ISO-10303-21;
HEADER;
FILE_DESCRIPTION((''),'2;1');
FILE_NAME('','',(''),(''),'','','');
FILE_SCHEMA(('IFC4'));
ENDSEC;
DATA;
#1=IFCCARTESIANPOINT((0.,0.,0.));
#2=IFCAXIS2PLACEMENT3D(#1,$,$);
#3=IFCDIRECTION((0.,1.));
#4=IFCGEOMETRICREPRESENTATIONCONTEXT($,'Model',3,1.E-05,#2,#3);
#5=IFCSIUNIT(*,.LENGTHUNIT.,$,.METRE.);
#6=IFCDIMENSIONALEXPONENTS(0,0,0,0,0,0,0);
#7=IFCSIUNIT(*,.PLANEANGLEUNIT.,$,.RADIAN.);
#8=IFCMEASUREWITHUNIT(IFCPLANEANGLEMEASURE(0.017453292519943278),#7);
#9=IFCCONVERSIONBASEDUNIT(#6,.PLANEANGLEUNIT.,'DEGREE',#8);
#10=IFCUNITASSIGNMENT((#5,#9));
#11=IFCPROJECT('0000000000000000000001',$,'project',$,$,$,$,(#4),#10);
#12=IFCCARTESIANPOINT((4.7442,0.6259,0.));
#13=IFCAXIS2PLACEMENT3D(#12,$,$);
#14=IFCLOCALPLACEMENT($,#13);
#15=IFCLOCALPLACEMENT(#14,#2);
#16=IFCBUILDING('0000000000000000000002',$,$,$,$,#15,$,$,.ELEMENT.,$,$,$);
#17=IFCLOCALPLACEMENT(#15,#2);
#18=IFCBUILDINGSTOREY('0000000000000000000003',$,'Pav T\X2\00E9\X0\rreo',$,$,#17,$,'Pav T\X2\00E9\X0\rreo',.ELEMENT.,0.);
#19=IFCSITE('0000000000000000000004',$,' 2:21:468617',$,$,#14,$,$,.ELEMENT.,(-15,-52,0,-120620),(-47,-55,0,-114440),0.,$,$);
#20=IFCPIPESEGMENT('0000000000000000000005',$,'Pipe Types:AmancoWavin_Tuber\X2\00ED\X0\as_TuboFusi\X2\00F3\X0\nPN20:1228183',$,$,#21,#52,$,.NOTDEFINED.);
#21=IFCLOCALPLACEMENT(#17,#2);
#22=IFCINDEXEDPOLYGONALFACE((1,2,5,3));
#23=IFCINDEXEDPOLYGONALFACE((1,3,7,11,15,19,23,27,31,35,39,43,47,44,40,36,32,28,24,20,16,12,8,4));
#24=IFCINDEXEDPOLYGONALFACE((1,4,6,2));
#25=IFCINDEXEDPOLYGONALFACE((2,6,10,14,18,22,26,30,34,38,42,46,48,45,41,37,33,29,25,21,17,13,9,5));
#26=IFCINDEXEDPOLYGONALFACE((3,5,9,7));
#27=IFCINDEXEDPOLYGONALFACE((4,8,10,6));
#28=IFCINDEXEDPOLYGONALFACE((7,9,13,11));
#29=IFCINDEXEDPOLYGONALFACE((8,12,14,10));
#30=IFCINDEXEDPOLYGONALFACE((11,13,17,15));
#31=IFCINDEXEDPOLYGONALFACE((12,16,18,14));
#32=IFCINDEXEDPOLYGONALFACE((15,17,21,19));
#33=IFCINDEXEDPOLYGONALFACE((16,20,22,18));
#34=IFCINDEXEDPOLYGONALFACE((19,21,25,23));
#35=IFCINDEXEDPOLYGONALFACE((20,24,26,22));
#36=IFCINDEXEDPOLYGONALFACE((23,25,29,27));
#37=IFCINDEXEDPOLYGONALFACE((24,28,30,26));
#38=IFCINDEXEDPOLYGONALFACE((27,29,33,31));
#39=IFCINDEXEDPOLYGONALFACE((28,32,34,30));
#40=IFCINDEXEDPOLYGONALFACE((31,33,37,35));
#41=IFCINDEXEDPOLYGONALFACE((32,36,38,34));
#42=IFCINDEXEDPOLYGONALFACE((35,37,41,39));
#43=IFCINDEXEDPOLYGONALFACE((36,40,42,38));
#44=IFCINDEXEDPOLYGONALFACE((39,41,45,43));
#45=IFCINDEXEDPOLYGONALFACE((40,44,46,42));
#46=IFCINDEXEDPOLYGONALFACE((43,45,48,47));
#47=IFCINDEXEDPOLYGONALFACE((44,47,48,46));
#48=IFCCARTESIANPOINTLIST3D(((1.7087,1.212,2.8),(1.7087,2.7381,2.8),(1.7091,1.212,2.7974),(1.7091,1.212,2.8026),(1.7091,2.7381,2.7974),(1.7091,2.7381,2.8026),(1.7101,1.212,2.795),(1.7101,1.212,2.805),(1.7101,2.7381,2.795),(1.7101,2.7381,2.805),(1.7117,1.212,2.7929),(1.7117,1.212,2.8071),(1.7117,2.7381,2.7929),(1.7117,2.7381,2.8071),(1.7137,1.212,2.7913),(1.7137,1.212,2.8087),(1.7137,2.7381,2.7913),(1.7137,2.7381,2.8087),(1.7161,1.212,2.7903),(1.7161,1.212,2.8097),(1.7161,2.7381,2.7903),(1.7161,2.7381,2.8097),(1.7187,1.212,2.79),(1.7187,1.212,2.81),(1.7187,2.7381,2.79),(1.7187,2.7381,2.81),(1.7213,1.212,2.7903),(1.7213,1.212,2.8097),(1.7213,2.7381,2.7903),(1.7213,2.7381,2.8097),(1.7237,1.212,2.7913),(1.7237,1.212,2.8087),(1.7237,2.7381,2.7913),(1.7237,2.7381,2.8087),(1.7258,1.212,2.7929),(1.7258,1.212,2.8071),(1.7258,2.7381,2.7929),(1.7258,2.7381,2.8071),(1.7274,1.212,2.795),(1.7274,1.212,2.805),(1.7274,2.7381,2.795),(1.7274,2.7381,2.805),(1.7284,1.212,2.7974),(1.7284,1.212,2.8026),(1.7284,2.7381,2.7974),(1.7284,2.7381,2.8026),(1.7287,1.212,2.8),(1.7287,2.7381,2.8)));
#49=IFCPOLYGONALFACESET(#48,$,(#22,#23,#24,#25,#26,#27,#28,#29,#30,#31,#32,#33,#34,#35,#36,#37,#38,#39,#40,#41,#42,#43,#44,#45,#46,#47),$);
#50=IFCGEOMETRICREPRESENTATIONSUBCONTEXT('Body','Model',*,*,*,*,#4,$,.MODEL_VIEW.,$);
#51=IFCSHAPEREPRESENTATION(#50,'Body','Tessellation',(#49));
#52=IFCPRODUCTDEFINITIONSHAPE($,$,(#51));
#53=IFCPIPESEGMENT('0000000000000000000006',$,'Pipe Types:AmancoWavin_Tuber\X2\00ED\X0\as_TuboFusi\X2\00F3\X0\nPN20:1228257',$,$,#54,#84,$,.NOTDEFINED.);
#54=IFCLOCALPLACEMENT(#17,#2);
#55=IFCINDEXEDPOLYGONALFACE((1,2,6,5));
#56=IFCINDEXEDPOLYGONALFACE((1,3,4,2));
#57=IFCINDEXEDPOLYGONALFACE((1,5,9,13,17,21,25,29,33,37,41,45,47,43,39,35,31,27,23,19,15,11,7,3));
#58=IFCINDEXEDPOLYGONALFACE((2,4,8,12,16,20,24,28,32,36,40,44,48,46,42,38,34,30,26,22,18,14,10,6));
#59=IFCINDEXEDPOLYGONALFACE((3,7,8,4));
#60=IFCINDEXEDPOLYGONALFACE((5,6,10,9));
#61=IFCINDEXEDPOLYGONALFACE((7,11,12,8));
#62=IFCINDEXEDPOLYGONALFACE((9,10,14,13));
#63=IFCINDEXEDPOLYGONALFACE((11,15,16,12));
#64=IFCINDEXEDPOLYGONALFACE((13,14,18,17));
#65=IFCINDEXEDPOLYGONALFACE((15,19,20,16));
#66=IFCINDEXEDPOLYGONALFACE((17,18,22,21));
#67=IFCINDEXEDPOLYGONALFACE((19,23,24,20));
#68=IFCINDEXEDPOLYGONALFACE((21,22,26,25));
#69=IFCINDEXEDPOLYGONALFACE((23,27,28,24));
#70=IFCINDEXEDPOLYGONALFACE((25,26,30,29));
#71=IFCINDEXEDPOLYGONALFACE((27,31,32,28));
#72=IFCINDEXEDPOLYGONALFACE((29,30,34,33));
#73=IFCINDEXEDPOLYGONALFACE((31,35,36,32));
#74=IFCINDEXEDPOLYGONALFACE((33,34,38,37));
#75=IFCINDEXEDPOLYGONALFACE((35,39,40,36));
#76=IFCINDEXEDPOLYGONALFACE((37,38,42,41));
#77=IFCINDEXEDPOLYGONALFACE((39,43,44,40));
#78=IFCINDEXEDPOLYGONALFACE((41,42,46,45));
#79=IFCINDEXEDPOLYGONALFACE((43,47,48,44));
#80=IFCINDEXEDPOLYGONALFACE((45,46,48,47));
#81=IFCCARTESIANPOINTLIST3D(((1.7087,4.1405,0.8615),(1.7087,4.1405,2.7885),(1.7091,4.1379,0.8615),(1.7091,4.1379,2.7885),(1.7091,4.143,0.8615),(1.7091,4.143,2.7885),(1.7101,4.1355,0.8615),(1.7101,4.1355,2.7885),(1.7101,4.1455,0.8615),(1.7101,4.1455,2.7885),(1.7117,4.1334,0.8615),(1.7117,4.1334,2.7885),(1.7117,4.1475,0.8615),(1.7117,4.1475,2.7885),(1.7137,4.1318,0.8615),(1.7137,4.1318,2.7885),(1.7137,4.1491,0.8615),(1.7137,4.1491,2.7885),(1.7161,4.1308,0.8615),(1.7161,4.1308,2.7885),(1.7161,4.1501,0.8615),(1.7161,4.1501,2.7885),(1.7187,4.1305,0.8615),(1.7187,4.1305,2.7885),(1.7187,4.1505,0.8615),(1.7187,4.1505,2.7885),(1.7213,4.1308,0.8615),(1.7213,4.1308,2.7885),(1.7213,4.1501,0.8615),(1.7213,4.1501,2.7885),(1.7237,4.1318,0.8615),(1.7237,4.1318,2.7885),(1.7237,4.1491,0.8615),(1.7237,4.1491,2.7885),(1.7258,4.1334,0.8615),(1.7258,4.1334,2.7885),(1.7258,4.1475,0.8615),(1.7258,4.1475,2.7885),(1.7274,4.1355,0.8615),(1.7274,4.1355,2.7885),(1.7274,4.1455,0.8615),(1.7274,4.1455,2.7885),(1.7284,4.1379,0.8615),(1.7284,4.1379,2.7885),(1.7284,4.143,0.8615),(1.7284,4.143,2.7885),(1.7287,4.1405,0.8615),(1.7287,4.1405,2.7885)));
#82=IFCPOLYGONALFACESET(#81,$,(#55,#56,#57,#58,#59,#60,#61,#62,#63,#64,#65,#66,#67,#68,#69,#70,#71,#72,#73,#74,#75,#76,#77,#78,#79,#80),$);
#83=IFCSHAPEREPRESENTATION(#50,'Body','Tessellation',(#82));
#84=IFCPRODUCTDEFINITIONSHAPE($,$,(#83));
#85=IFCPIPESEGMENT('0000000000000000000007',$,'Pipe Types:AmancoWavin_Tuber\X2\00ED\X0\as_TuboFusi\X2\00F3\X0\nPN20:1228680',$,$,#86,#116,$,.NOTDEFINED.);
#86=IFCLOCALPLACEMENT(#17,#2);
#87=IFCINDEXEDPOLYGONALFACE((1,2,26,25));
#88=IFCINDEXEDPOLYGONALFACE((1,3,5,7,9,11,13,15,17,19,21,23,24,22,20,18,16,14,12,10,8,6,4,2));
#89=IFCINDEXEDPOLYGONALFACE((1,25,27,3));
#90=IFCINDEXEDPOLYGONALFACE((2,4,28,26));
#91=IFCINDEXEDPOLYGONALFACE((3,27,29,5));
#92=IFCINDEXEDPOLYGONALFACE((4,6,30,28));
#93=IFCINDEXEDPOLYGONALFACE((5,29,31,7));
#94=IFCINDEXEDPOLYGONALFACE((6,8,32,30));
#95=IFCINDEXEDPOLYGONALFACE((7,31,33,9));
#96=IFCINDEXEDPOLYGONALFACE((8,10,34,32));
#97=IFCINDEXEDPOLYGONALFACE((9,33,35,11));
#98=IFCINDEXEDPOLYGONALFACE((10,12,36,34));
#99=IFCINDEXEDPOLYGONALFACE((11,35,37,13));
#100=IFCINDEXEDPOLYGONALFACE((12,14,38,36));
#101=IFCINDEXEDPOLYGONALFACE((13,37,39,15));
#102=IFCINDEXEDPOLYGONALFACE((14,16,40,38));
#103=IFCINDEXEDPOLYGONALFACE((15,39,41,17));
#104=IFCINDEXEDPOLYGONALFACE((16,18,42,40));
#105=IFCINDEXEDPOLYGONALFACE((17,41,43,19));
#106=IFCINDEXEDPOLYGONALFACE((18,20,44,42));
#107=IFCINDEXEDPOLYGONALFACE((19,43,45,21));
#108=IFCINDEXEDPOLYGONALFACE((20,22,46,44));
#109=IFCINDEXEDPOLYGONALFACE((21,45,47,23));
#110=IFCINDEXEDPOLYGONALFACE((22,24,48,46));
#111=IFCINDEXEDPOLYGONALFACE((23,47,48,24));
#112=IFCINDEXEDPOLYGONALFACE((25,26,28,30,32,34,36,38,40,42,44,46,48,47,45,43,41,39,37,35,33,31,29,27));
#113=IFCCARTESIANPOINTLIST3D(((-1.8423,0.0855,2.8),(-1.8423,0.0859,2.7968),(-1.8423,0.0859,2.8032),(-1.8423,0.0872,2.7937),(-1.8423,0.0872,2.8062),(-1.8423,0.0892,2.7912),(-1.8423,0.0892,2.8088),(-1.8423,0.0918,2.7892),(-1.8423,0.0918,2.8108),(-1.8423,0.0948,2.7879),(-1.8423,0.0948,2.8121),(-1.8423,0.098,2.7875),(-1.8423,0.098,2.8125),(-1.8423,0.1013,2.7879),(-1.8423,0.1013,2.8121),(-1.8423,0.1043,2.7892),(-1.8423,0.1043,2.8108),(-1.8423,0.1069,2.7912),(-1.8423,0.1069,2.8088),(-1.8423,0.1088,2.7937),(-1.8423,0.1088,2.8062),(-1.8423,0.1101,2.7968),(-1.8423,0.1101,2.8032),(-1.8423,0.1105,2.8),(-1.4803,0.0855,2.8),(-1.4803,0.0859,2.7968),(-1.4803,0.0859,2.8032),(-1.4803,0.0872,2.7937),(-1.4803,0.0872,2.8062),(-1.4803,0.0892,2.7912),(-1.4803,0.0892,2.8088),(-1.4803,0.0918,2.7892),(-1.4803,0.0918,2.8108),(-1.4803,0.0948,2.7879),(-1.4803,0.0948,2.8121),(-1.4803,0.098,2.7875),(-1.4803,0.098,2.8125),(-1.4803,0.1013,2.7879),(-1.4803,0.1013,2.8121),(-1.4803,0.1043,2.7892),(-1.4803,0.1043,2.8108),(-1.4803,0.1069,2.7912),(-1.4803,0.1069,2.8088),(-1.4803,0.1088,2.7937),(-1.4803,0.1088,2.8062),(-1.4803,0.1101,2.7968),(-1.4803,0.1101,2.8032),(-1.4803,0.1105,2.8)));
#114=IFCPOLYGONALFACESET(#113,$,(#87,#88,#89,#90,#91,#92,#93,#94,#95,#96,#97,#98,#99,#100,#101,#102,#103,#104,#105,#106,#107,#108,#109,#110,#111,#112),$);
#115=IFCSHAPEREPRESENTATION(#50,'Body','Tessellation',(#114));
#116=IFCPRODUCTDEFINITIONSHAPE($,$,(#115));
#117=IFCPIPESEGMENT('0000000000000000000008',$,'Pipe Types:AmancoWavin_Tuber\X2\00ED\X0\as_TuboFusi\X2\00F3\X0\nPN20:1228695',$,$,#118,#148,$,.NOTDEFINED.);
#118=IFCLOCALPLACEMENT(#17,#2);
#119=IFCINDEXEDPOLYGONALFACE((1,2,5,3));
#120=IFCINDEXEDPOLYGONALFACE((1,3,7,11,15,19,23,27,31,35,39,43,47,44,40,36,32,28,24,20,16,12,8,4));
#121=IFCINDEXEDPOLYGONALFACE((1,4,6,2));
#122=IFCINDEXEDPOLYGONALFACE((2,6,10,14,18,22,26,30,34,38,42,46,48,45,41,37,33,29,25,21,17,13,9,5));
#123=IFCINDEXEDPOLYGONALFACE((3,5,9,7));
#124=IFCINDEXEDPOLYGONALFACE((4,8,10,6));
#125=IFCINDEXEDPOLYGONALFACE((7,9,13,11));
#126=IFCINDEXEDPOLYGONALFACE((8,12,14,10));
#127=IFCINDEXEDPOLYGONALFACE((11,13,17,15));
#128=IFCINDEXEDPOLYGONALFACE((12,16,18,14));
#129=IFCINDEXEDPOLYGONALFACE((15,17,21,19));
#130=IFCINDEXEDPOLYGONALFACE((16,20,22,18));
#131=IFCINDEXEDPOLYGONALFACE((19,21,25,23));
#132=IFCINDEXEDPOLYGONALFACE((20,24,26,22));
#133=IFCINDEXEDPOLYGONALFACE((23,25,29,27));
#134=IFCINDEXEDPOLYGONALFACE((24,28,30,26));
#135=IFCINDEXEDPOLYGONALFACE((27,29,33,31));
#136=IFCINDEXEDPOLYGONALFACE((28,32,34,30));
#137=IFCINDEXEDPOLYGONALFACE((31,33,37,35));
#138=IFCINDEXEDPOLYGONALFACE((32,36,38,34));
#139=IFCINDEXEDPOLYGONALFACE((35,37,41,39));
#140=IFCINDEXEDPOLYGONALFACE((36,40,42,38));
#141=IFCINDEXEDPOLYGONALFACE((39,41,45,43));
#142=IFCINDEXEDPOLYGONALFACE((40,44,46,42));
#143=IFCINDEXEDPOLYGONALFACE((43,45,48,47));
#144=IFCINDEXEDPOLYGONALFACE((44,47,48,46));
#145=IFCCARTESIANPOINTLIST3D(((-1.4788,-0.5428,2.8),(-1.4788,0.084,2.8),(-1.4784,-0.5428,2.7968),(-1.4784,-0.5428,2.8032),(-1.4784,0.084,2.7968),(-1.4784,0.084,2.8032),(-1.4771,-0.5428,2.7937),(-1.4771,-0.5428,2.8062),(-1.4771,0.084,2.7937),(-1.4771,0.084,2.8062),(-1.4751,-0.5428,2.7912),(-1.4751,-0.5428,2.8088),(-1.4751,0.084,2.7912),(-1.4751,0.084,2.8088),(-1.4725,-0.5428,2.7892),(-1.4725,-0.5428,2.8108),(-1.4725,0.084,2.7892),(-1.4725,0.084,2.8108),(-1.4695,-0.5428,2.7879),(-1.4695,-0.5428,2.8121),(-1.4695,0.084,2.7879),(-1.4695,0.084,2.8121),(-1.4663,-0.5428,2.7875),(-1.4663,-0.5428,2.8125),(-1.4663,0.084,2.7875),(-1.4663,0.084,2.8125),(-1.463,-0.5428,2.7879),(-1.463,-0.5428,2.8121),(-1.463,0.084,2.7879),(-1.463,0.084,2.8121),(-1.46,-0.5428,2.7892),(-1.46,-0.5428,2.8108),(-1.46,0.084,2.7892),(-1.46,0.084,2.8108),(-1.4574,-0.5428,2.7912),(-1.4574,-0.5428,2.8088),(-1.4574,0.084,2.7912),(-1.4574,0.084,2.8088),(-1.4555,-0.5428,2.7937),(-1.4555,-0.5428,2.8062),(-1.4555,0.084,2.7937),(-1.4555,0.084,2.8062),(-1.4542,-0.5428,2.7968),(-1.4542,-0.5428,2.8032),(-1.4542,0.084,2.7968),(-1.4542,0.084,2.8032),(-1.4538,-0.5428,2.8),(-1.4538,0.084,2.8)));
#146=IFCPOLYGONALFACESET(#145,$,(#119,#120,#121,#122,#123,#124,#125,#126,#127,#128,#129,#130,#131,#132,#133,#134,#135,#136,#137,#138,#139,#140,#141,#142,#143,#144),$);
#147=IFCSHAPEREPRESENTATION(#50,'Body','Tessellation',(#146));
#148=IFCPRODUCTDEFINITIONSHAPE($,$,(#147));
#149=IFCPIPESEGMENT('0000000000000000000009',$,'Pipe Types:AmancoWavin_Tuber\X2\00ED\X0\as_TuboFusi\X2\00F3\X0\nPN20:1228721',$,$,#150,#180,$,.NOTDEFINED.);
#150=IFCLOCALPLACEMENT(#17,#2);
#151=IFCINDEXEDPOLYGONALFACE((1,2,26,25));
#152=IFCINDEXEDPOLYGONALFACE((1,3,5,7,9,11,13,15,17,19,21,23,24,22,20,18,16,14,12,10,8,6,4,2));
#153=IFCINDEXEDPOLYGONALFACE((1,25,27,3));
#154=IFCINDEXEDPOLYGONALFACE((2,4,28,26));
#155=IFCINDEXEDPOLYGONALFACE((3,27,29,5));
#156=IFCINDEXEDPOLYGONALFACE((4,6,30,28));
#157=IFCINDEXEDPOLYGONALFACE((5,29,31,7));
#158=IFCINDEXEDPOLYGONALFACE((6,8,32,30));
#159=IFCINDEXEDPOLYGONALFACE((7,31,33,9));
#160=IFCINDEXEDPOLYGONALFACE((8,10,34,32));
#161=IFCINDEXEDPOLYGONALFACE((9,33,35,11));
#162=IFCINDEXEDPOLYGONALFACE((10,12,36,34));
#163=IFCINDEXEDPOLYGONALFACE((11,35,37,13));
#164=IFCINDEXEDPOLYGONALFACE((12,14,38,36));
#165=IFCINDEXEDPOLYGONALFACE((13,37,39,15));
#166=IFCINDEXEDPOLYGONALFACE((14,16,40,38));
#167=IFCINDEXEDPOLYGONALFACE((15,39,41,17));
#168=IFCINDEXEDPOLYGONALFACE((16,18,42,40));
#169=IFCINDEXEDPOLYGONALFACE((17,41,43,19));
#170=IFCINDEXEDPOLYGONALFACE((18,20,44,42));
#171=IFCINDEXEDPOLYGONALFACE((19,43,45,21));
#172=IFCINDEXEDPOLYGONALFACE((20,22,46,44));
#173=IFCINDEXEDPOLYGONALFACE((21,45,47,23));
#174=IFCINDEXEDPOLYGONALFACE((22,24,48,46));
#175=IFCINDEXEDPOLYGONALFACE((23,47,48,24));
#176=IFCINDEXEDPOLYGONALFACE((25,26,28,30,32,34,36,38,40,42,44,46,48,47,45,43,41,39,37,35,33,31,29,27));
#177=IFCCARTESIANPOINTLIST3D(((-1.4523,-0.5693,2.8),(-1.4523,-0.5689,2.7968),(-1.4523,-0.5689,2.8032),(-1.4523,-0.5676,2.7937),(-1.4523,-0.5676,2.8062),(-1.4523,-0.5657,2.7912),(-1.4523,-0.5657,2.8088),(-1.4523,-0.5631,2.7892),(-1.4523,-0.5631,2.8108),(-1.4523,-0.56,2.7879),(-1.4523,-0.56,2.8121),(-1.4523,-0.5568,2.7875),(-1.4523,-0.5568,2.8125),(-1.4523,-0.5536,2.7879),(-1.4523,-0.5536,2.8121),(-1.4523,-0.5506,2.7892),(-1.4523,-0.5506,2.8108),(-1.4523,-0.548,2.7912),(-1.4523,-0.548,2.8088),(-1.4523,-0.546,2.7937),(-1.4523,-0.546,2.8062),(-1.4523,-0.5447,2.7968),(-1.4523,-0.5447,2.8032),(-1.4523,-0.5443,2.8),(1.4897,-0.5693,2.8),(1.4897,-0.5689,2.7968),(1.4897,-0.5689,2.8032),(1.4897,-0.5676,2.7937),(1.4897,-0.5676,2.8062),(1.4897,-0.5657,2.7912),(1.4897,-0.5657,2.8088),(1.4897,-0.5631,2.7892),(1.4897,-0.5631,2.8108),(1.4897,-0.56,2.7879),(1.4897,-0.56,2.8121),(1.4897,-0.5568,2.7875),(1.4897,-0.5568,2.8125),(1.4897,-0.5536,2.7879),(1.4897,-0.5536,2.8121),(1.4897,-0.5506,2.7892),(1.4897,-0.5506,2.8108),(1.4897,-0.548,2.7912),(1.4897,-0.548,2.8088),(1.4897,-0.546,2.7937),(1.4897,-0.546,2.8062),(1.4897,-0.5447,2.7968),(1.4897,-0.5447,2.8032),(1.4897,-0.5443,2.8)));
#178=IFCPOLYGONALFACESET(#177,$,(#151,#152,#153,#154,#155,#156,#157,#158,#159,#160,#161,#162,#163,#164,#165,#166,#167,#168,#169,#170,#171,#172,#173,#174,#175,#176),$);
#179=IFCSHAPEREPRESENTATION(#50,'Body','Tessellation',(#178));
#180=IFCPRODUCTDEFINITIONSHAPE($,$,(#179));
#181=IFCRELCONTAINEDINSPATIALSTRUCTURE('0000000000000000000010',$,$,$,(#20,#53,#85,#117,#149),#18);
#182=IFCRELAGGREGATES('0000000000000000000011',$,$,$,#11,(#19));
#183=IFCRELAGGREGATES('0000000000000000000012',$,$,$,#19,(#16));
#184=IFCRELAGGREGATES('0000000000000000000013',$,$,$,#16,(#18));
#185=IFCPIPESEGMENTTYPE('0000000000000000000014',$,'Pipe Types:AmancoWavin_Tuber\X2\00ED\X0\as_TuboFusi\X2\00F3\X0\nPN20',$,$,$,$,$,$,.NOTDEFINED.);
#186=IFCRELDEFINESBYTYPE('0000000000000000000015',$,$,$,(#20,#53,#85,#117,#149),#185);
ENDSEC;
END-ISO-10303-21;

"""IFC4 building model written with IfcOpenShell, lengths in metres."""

from ifc_helpers import new_model, entity, si_unit, converted_unit, direction, frame, origin, place, context, subcontext, project, spatial, arc, indexed_curve, outline, extrude, type_object, element, save


model = new_model("IFC4")

# Units and contexts
model_context = context("Model", 3, precision=1e-05, world=origin(), true_north=direction((0.0, 1.0)))
body_context = subcontext(model_context, "Body", "Model", "MODEL_VIEW")
ifc_project = project(units=[si_unit("LENGTHUNIT", "METRE"), converted_unit("PLANEANGLEUNIT", "DEGREE", entity("IfcPlaneAngleMeasure", 0.017453292519943278), si_unit("PLANEANGLEUNIT", "RADIAN"), dimensions=[0, 0, 0, 0, 0, 0, 0])], contexts=[model_context])

# Site, building, storey
site_placement = place(None, frame((4.7442, 0.6259, 0.0)))
site = spatial("IfcSite", under=ifc_project, at=site_placement, Name=" 2:21:468617", CompositionType="ELEMENT", RefLatitude=(-15, -52, 0, -120620), RefLongitude=(-47, -55, 0, -114440), RefElevation=0.0)
building_placement = place(site_placement, origin())
building = spatial("IfcBuilding", under=site, at=building_placement, CompositionType="ELEMENT")
storey_placement = place(building_placement, origin())
storey = spatial("IfcBuildingStorey", under=building, at=storey_placement, Name="Pav Térreo", LongName="Pav Térreo", CompositionType="ELEMENT", Elevation=0.0)

# Pipe segments
pipe_segment_type_1 = type_object("IfcPipeSegmentType", Name="Pipe Types:AmancoWavin_Tuberías_TuboFusiónPN20", PredefinedType="NOTDEFINED")
pipe_segment_1_placement = place(storey_placement, origin())
element("IfcPipeSegment", 1, at=pipe_segment_1_placement, inside=storey, type_object=pipe_segment_type_1, Name="Pipe Types:AmancoWavin_Tuberías_TuboFusiónPN20:1228183", PredefinedType="NOTDEFINED", context=body_context, shape_type="SweptSolid", body=[
    extrude(outline(indexed_curve([(0.01, 0.0), (0.0071, 0.0071), (0.0, 0.01), (-0.0071, 0.0071), (-0.01, 0.0), (-0.0071, -0.0071), (0.0, -0.01), (0.0071, -0.0071)], segments=[arc(1, 2, 3), arc(3, 4, 5), arc(5, 6, 7), arc(7, 8, 1)], self_intersect=False)), frame((1.7187, 1.212, 2.8), z_axis=(0.0, 1.0, 0.0), x_axis=(1.0, 0.0, 0.0)), (0.0, 0.0, 1.0), 1.5261),
])
pipe_segment_2_placement = place(storey_placement, origin())
element("IfcPipeSegment", 2, at=pipe_segment_2_placement, inside=storey, type_object=pipe_segment_type_1, Name="Pipe Types:AmancoWavin_Tuberías_TuboFusiónPN20:1228257", PredefinedType="NOTDEFINED", context=body_context, shape_type="SweptSolid", body=[
    extrude(outline(indexed_curve([(0.01, 0.0), (0.0071, 0.0071), (0.0, 0.01), (-0.0071, 0.0071), (-0.01, 0.0), (-0.0071, -0.0071), (0.0, -0.01), (0.0071, -0.0071)], segments=[arc(1, 2, 3), arc(3, 4, 5), arc(5, 6, 7), arc(7, 8, 1)], self_intersect=False)), frame((1.7187, 4.1405, 0.8615)), (0.0, 0.0, 1.0), 1.927),
])
pipe_segment_3_placement = place(storey_placement, origin())
element("IfcPipeSegment", 3, at=pipe_segment_3_placement, inside=storey, type_object=pipe_segment_type_1, Name="Pipe Types:AmancoWavin_Tuberías_TuboFusiónPN20:1228680", PredefinedType="NOTDEFINED", context=body_context, shape_type="SweptSolid", body=[
    extrude(outline(indexed_curve([(0.0125, 0.0), (0.0088, 0.0088), (0.0, 0.0125), (-0.0088, 0.0088), (-0.0125, 0.0), (-0.0088, -0.0088), (0.0, -0.0125), (0.0088, -0.0088)], segments=[arc(1, 2, 3), arc(3, 4, 5), arc(5, 6, 7), arc(7, 8, 1)], self_intersect=False)), frame((-1.8423, 0.098, 2.8), z_axis=(1.0, 0.0, 0.0), x_axis=(0.0, -1.0, 0.0)), (0.0, 0.0, 1.0), 0.362),
])
pipe_segment_4_placement = place(storey_placement, origin())
element("IfcPipeSegment", 4, at=pipe_segment_4_placement, inside=storey, type_object=pipe_segment_type_1, Name="Pipe Types:AmancoWavin_Tuberías_TuboFusiónPN20:1228695", PredefinedType="NOTDEFINED", context=body_context, shape_type="SweptSolid", body=[
    extrude(outline(indexed_curve([(0.0125, 0.0), (0.0088, 0.0088), (0.0, 0.0125), (-0.0088, 0.0088), (-0.0125, 0.0), (-0.0088, -0.0088), (0.0, -0.0125), (0.0088, -0.0088)], segments=[arc(1, 2, 3), arc(3, 4, 5), arc(5, 6, 7), arc(7, 8, 1)], self_intersect=False)), frame((-1.4663, -0.5428, 2.8), z_axis=(0.0, 1.0, 0.0), x_axis=(-1.0, 0.0, 0.0)), (0.0, 0.0, 1.0), 0.6268),
])
pipe_segment_5_placement = place(storey_placement, origin())
element("IfcPipeSegment", 5, at=pipe_segment_5_placement, inside=storey, type_object=pipe_segment_type_1, Name="Pipe Types:AmancoWavin_Tuberías_TuboFusiónPN20:1228721", PredefinedType="NOTDEFINED", context=body_context, shape_type="SweptSolid", body=[
    extrude(outline(indexed_curve([(0.0125, 0.0), (0.0088, 0.0088), (0.0, 0.0125), (-0.0088, 0.0088), (-0.0125, 0.0), (-0.0088, -0.0088), (0.0, -0.0125), (0.0088, -0.0088)], segments=[arc(1, 2, 3), arc(3, 4, 5), arc(5, 6, 7), arc(7, 8, 1)], self_intersect=False)), frame((-1.4523, -0.5568, 2.8), z_axis=(1.0, 0.0, 0.0), x_axis=(0.0, -1.0, 0.0)), (0.0, 0.0, 1.0), 2.942),
])

save(model, "model.ifc")
